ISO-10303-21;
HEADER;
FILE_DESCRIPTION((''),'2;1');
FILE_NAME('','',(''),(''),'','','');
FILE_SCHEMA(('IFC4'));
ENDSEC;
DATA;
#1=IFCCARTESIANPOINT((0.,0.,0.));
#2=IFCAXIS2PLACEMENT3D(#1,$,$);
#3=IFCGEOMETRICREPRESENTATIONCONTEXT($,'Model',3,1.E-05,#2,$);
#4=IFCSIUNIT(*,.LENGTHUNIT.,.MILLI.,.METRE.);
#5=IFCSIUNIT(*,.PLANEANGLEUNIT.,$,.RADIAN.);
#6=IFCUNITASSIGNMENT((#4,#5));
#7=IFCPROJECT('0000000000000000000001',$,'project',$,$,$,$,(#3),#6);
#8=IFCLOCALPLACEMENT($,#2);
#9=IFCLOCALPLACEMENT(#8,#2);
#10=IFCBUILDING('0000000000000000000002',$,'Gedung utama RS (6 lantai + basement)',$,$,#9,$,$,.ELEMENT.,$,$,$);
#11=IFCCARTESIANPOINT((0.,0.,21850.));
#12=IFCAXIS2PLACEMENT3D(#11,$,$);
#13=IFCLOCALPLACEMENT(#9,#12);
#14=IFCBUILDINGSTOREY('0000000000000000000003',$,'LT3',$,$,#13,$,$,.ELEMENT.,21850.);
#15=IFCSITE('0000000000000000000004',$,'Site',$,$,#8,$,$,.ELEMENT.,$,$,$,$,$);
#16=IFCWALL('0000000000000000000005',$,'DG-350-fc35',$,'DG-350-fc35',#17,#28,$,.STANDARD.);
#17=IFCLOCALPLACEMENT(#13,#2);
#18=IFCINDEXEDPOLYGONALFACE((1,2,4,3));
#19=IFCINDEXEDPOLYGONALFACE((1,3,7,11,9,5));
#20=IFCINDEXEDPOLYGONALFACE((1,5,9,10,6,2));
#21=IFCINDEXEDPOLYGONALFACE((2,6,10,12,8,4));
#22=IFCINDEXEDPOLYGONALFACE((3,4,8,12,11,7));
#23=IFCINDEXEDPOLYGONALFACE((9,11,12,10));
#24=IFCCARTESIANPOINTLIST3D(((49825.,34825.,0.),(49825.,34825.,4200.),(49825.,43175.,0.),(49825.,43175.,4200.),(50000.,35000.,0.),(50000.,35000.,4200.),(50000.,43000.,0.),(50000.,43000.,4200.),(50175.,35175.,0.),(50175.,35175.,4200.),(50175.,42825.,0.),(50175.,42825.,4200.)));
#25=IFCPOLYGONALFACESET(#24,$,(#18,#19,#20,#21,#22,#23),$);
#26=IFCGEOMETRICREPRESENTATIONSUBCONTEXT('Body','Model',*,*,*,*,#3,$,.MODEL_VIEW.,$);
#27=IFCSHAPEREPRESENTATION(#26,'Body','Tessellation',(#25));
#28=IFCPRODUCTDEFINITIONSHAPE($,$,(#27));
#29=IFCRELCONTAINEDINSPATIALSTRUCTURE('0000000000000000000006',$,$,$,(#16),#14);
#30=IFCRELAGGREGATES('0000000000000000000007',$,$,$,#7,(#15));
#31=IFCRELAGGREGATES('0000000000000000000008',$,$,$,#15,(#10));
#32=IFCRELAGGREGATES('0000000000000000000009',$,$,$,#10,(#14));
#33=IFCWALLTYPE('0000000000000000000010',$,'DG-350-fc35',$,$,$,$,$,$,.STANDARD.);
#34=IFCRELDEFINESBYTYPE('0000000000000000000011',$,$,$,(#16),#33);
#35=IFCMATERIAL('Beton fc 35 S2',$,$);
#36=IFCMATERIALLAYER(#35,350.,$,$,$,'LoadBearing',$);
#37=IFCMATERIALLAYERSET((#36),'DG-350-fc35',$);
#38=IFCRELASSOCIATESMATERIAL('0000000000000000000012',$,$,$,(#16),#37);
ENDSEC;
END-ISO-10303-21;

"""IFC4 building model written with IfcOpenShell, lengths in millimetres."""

from ifc_helpers import new_model, si_unit, frame, origin, place, context, subcontext, project, spatial, polyline, outline, extrude, material, layer, layer_set, layer_usage, type_object, element, save


model = new_model("IFC4")

# Units and contexts
model_context = context("Model", 3, precision=1e-05, world=origin())
body_context = subcontext(model_context, "Body", "Model", "MODEL_VIEW")
ifc_project = project(units=[si_unit("LENGTHUNIT", "METRE", prefix="MILLI"), si_unit("PLANEANGLEUNIT", "RADIAN")], contexts=[model_context])

# Site, building, storey
site_placement = place(None, origin())
site = spatial("IfcSite", under=ifc_project, at=site_placement, Name="Site", CompositionType="ELEMENT")
building_placement = place(site_placement, origin())
building = spatial("IfcBuilding", under=site, at=building_placement, Name="Gedung utama RS (6 lantai + basement)", CompositionType="ELEMENT")
storey_placement = place(building_placement, frame((0.0, 0.0, 21850.0)))
storey = spatial("IfcBuildingStorey", under=building, at=storey_placement, Name="LT3", CompositionType="ELEMENT", Elevation=21850.0)

# Shared definitions
ifc_material_1 = material(Name="Beton fc 35 S2")
ifc_layer = layer(ifc_material_1, 350.0, Category="LoadBearing")
ifc_layer_set = layer_set([ifc_layer], Name="DG-350-fc35")
ifc_layer_usage = layer_usage(ifc_layer_set, "AXIS2", "NEGATIVE", 175.0)
wall_type = type_object("IfcWallType", Name="DG-350-fc35", PredefinedType="STANDARD")

# Wall
for number, where, z_axis, x_axis, name in (
    (1, (50000.0, 43000.0, 0.0), (0.0, 0.0, 1.0), (0.0, -1.0, 0.0), "DG-350-fc35"),
):
    element("IfcWall", number, at=place(storey_placement, frame(where, z_axis=z_axis, x_axis=x_axis)), inside=storey, type_object=wall_type, material=ifc_layer_usage, Name=name, ObjectType="DG-350-fc35", PredefinedType="STANDARD", context=body_context, shape_type="SweptSolid", body=[
        extrude(outline(polyline([(-175.0, -175.0), (0.0, 0.0), (175.0, 175.0), (7825.0, 175.0), (8000.0, 0.0), (8175.0, -175.0), (-175.0, -175.0)])), origin(), (0.0, 0.0, 1.0), 4200.0),
    ])

save(model, "model.ifc")
